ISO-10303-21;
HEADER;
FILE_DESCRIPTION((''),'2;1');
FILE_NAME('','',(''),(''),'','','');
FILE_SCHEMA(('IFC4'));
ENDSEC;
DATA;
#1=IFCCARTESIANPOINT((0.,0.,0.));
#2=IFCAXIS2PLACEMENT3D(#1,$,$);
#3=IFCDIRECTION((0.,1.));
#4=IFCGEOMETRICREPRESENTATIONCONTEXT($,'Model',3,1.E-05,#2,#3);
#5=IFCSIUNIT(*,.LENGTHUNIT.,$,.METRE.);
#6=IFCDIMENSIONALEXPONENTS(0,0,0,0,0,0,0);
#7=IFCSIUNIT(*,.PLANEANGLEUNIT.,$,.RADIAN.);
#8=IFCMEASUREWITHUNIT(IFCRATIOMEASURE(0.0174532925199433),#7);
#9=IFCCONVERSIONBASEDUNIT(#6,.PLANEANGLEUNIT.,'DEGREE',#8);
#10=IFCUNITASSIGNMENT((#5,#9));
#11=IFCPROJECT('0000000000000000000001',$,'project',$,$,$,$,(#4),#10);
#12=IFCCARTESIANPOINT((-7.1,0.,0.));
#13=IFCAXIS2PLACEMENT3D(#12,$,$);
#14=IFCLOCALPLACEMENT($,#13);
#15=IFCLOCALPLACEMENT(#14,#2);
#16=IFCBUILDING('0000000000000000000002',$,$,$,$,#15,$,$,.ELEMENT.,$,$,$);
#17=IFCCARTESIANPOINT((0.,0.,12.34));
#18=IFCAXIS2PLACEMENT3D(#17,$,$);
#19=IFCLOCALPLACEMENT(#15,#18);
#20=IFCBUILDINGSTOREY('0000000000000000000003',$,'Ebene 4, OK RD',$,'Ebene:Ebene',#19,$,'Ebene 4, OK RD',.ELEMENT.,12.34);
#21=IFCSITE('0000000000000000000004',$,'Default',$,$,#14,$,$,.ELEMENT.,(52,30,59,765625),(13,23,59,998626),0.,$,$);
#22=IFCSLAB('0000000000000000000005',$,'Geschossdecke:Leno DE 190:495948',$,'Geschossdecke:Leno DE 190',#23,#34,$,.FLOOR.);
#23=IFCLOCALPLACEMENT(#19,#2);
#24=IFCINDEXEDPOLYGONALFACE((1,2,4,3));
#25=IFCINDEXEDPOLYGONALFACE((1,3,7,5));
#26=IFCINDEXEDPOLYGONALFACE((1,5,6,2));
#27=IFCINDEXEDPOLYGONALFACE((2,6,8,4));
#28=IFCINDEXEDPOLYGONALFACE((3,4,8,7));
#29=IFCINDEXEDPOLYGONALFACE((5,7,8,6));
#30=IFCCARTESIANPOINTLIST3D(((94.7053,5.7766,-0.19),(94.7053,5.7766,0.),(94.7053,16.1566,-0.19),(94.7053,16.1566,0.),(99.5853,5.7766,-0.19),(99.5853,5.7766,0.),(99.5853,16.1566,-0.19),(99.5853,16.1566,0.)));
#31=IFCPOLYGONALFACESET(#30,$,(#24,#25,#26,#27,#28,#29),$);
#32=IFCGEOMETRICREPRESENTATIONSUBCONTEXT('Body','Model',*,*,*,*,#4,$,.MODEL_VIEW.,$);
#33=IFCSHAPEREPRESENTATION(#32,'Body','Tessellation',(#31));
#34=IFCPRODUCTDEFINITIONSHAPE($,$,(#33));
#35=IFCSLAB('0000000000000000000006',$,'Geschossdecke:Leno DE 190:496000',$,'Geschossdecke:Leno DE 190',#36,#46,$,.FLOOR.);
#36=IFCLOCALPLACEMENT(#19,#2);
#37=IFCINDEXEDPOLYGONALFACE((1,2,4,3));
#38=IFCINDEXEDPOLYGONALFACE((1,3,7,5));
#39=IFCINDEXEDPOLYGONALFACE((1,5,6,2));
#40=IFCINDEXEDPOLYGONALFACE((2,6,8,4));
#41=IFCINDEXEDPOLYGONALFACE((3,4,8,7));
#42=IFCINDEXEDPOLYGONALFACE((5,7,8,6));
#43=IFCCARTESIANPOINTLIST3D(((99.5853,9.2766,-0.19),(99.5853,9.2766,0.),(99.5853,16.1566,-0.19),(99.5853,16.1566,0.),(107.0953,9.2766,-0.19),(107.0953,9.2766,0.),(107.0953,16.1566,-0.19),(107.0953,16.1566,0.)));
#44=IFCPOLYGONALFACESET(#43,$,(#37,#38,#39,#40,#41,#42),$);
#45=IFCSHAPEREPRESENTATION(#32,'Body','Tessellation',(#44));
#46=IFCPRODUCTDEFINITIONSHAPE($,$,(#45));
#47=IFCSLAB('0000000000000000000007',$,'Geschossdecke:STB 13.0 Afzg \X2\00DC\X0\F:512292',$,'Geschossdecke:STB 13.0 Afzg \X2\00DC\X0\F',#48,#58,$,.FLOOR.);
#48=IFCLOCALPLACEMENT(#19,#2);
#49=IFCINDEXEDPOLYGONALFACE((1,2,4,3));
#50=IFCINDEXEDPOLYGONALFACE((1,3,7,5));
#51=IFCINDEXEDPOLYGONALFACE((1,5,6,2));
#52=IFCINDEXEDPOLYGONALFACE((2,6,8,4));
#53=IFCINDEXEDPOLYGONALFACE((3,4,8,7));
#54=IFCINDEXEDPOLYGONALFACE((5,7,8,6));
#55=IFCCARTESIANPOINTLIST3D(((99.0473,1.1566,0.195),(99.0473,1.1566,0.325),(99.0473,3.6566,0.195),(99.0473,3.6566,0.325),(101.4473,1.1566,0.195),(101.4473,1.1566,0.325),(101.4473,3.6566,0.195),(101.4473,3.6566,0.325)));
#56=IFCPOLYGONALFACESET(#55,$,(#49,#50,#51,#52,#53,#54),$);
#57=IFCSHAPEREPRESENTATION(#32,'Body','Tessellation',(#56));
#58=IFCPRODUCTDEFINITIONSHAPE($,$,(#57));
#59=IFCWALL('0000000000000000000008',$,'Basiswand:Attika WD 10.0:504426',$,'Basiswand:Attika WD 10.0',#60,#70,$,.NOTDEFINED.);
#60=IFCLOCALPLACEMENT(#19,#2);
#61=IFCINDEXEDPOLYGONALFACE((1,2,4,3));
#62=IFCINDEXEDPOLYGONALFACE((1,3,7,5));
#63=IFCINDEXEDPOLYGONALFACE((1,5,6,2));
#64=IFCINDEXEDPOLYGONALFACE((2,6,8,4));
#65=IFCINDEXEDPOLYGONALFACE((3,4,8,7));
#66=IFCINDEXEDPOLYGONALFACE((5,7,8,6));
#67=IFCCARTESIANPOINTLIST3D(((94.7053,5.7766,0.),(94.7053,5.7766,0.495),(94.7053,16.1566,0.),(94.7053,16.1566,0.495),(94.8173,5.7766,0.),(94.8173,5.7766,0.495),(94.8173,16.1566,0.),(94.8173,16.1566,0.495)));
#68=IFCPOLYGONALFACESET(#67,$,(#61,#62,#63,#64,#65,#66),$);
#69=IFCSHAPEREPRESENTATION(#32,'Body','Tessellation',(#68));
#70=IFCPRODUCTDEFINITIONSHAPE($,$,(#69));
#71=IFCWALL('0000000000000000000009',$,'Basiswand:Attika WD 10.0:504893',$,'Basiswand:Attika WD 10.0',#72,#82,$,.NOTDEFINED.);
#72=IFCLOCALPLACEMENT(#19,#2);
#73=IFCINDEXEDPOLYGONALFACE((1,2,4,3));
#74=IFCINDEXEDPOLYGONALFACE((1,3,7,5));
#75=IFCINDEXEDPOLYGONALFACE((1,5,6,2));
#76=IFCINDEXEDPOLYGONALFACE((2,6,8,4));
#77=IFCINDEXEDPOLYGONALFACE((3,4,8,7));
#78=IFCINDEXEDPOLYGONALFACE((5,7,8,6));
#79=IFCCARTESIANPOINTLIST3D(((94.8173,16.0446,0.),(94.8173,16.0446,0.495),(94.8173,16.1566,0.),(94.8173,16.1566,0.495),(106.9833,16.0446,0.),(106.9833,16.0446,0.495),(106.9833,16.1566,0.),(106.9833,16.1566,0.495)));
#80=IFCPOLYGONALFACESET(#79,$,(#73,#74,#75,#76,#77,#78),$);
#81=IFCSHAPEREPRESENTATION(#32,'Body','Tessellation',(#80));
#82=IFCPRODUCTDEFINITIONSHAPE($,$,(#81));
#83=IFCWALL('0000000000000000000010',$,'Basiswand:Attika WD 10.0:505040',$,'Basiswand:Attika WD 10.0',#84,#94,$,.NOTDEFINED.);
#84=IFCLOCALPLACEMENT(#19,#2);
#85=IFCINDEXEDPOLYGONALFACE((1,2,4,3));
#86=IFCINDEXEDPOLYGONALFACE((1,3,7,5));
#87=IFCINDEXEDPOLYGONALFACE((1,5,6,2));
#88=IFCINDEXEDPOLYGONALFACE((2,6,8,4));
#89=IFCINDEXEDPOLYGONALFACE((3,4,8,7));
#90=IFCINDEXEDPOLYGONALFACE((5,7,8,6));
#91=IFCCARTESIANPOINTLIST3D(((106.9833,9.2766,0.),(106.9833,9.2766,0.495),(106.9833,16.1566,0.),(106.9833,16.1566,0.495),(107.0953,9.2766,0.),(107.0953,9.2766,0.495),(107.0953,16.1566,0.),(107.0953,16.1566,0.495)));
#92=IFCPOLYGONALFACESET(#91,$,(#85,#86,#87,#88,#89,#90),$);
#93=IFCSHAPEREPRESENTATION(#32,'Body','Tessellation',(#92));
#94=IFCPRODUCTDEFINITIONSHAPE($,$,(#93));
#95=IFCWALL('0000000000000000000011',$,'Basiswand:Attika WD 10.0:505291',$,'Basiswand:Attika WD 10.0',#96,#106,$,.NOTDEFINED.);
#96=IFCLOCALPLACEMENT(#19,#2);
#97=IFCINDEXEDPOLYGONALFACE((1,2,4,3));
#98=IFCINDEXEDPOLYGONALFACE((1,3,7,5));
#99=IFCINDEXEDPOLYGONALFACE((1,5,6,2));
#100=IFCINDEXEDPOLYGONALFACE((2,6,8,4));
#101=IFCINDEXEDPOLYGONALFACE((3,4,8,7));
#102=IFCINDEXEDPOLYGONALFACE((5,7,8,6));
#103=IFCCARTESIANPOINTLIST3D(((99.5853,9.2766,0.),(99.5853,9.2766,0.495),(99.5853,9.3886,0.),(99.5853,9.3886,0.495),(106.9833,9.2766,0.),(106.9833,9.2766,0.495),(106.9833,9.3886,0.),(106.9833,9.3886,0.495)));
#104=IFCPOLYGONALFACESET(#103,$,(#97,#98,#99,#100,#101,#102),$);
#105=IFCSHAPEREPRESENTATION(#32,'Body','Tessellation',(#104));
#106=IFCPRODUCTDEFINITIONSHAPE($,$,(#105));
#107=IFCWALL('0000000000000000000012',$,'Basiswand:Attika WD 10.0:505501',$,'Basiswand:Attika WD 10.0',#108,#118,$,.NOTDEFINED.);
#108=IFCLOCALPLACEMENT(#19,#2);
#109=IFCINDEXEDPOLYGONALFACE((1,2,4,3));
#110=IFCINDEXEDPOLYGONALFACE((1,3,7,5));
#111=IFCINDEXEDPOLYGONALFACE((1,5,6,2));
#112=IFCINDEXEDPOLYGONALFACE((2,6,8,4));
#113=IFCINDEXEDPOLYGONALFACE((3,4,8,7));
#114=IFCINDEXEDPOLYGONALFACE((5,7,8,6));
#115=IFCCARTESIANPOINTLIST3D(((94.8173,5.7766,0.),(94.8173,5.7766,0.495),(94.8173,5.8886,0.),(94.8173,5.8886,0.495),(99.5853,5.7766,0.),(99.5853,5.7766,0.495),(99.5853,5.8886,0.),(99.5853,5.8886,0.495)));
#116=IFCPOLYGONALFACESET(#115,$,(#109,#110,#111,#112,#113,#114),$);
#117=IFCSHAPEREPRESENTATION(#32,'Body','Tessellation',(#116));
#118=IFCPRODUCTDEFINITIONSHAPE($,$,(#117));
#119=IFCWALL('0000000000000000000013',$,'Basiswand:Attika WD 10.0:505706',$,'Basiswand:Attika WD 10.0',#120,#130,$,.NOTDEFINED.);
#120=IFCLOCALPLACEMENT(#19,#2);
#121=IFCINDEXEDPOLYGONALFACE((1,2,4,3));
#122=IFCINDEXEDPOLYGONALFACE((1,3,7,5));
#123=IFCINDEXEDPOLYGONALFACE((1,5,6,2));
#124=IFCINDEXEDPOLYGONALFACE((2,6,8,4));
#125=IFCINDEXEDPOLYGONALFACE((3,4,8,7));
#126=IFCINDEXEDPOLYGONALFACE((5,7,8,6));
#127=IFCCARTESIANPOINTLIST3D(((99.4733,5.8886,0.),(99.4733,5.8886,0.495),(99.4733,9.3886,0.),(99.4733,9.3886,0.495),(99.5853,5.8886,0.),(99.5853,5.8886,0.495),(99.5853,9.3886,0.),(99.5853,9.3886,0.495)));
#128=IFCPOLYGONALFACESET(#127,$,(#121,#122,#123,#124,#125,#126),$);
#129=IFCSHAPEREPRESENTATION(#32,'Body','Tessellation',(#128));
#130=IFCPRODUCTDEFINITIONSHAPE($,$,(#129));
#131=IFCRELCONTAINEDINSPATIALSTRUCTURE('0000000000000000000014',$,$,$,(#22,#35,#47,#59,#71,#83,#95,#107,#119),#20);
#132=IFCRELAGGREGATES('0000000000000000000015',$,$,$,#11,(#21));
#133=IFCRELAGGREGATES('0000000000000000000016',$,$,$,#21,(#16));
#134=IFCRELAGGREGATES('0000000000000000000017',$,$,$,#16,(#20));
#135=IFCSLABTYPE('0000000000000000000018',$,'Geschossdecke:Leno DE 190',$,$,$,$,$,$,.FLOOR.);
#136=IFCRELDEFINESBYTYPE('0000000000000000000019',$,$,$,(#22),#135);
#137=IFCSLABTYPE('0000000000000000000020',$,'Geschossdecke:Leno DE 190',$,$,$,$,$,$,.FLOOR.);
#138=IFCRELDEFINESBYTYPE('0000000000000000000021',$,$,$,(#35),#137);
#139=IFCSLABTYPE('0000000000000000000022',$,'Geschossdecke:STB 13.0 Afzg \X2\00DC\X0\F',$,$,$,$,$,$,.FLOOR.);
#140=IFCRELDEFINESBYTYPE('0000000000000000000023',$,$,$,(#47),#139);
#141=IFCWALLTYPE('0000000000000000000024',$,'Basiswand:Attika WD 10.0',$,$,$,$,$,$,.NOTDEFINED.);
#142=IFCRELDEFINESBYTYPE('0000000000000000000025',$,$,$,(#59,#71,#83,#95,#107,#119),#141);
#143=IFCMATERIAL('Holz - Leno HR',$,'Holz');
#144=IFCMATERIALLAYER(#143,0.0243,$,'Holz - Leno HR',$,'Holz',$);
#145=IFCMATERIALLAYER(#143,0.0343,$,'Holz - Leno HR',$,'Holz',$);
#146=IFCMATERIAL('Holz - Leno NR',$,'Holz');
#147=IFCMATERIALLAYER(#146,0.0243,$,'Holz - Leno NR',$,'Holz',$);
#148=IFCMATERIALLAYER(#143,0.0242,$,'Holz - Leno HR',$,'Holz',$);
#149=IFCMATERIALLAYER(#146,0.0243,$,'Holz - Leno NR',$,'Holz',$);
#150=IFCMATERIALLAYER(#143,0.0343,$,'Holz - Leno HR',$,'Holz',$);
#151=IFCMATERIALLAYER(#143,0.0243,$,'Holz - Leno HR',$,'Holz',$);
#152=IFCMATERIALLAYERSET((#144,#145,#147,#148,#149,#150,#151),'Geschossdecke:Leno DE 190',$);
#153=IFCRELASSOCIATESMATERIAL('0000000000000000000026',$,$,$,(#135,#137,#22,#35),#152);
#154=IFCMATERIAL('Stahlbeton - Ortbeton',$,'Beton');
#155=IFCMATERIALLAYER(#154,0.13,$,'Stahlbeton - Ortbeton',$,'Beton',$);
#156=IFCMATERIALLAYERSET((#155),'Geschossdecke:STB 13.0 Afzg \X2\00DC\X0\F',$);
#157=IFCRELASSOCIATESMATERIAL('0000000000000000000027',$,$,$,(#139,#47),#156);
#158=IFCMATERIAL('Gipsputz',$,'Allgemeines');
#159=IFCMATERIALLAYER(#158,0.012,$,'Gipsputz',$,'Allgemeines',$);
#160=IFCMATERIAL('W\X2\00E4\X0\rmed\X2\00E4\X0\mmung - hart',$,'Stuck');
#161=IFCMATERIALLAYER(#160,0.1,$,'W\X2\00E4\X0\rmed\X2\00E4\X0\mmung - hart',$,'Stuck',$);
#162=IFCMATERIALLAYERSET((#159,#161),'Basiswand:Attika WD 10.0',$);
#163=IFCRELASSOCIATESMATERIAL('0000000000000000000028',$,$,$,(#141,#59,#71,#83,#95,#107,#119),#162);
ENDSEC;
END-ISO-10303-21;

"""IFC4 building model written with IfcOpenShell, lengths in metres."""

from ifc_helpers import new_model, entity, si_unit, converted_unit, direction, frame, frame_2d, origin, origin_2d_with_axis, place, context, subcontext, project, spatial, rectangle, extrude, material, layer, layer_set, layer_usage, type_object, element, save


model = new_model("IFC4")

# Units and contexts
model_context = context("Model", 3, precision=1e-05, world=origin(), true_north=direction((0.0, 1.0)))
body_context = subcontext(model_context, "Body", "Model", "MODEL_VIEW")
ifc_project = project(units=[si_unit("LENGTHUNIT", "METRE"), converted_unit("PLANEANGLEUNIT", "DEGREE", entity("IfcRatioMeasure", 0.0174532925199433), si_unit("PLANEANGLEUNIT", "RADIAN"), dimensions=[0, 0, 0, 0, 0, 0, 0])], contexts=[model_context])

# Site, building, storey
site_placement = place(None, frame((-7.1, 0.0, 0.0)))
site = spatial("IfcSite", under=ifc_project, at=site_placement, Name="Default", CompositionType="ELEMENT", RefLatitude=(52, 30, 59, 765625), RefLongitude=(13, 23, 59, 998626), RefElevation=0.0)
building_placement = place(site_placement, origin())
building = spatial("IfcBuilding", under=site, at=building_placement, CompositionType="ELEMENT")
storey_placement = place(building_placement, frame((0.0, 0.0, 12.34)))
storey = spatial("IfcBuildingStorey", under=building, at=storey_placement, Name="Ebene 4, OK RD", ObjectType="Ebene:Ebene", LongName="Ebene 4, OK RD", CompositionType="ELEMENT", Elevation=12.34)

# Slabs
ifc_material_1 = material(Name="Holz - Leno HR", Category="Holz")
ifc_layer_1 = layer(ifc_material_1, 0.0243, Name="Holz - Leno HR", Category="Holz")
ifc_layer_2 = layer(ifc_material_1, 0.0343, Name="Holz - Leno HR", Category="Holz")
ifc_material_2 = material(Name="Holz - Leno NR", Category="Holz")
ifc_layer_3 = layer(ifc_material_2, 0.0243, Name="Holz - Leno NR", Category="Holz")
ifc_layer_4 = layer(ifc_material_1, 0.0242, Name="Holz - Leno HR", Category="Holz")
ifc_layer_5 = layer(ifc_material_2, 0.0243, Name="Holz - Leno NR", Category="Holz")
ifc_layer_6 = layer(ifc_material_1, 0.0343, Name="Holz - Leno HR", Category="Holz")
ifc_layer_7 = layer(ifc_material_1, 0.0243, Name="Holz - Leno HR", Category="Holz")
ifc_layer_set_1 = layer_set([ifc_layer_1, ifc_layer_2, ifc_layer_3, ifc_layer_4, ifc_layer_5, ifc_layer_6, ifc_layer_7], Name="Geschossdecke:Leno DE 190")
ifc_layer_usage_1 = layer_usage(ifc_layer_set_1, "AXIS3", "POSITIVE", 0.0)
slab_type_1 = type_object("IfcSlabType", Name="Geschossdecke:Leno DE 190", PredefinedType="FLOOR", material=ifc_layer_set_1)
slab_1_placement = place(storey_placement, origin())
element("IfcSlab", 1, at=slab_1_placement, inside=storey, type_object=slab_type_1, material=ifc_layer_usage_1, Name="Geschossdecke:Leno DE 190:495948", ObjectType="Geschossdecke:Leno DE 190", PredefinedType="FLOOR", context=body_context, shape_type="SweptSolid", body=[
    extrude(rectangle(XDim=10.38, YDim=4.88, at=frame_2d((0.0, 0.0), x_axis=(1.0, 0.0))), frame((97.1453, 10.9666, 0.0), z_axis=(0.0, 0.0, -1.0), x_axis=(0.0, 1.0, 0.0)), (0.0, 0.0, 1.0), 0.19),
])
ifc_layer_usage_2 = layer_usage(ifc_layer_set_1, "AXIS3", "POSITIVE", 0.0)
slab_type_2 = type_object("IfcSlabType", Name="Geschossdecke:Leno DE 190", PredefinedType="FLOOR", material=ifc_layer_set_1)
slab_2_placement = place(storey_placement, origin())
element("IfcSlab", 2, at=slab_2_placement, inside=storey, type_object=slab_type_2, material=ifc_layer_usage_2, Name="Geschossdecke:Leno DE 190:496000", ObjectType="Geschossdecke:Leno DE 190", PredefinedType="FLOOR", context=body_context, shape_type="SweptSolid", body=[
    extrude(rectangle(XDim=6.88, YDim=7.51, at=frame_2d((0.0, 0.0), x_axis=(1.0, 0.0))), frame((103.3403, 12.7166, 0.0), z_axis=(0.0, 0.0, -1.0), x_axis=(0.0, 1.0, 0.0)), (0.0, 0.0, 1.0), 0.19),
])
ifc_material_3 = material(Name="Wärmedämmung - hart", Category="Stuck")
ifc_material_4 = material(Name="Stahlbeton - Ortbeton", Category="Beton")
ifc_layer_8 = layer(ifc_material_4, 0.13, Name="Stahlbeton - Ortbeton", Category="Beton")
ifc_layer_set_2 = layer_set([ifc_layer_8], Name="Geschossdecke:STB 13.0 Afzg ÜF")
ifc_layer_usage_3 = layer_usage(ifc_layer_set_2, "AXIS3", "POSITIVE", 0.0)
slab_type_3 = type_object("IfcSlabType", Name="Geschossdecke:STB 13.0 Afzg ÜF", PredefinedType="FLOOR", material=ifc_layer_set_2)
slab_3_placement = place(storey_placement, origin())
element("IfcSlab", 3, at=slab_3_placement, inside=storey, type_object=slab_type_3, material=ifc_layer_usage_3, Name="Geschossdecke:STB 13.0 Afzg ÜF:512292", ObjectType="Geschossdecke:STB 13.0 Afzg ÜF", PredefinedType="FLOOR", context=body_context, shape_type="SweptSolid", body=[
    extrude(rectangle(XDim=2.5, YDim=2.4, at=origin_2d_with_axis()), frame((100.2473, 2.4066, 0.325), z_axis=(0.0, 0.0, -1.0), x_axis=(0.0, 1.0, 0.0)), (0.0, 0.0, 1.0), 0.13),
])

# Walls
ifc_material_5 = material(Name="Gipsputz", Category="Allgemeines")
ifc_layer_9 = layer(ifc_material_5, 0.012, Name="Gipsputz", Category="Allgemeines")
ifc_layer_10 = layer(ifc_material_3, 0.1, Name="Wärmedämmung - hart", Category="Stuck")
ifc_layer_set_3 = layer_set([ifc_layer_9, ifc_layer_10], Name="Basiswand:Attika WD 10.0")
ifc_layer_usage_4 = layer_usage(ifc_layer_set_3, "AXIS2", "NEGATIVE", 0.056)
wall_type = type_object("IfcWallType", Name="Basiswand:Attika WD 10.0", PredefinedType="NOTDEFINED", material=ifc_layer_set_3)
wall_1_placement = place(storey_placement, frame((94.7613, 16.1566, 0.0), z_axis=(0.0, 0.0, 1.0), x_axis=(0.0, -1.0, 0.0)))
element("IfcWall", 4, at=wall_1_placement, inside=storey, type_object=wall_type, material=ifc_layer_usage_4, Name="Basiswand:Attika WD 10.0:504426", ObjectType="Basiswand:Attika WD 10.0", PredefinedType="NOTDEFINED", context=body_context, shape_type="SweptSolid", body=[
    extrude(rectangle(XDim=10.38, YDim=0.112, at=frame_2d((5.19, 0.0), x_axis=(-1.0, 0.0))), origin(), (0.0, 0.0, 1.0), 0.495),
])
ifc_layer_usage_5 = layer_usage(ifc_layer_set_3, "AXIS2", "NEGATIVE", 0.056)
wall_2_placement = place(storey_placement, frame((106.9833, 16.1006, 0.0), z_axis=(0.0, 0.0, 1.0), x_axis=(-1.0, 0.0, 0.0)))
element("IfcWall", 5, at=wall_2_placement, inside=storey, type_object=wall_type, material=ifc_layer_usage_5, Name="Basiswand:Attika WD 10.0:504893", ObjectType="Basiswand:Attika WD 10.0", PredefinedType="NOTDEFINED", context=body_context, shape_type="SweptSolid", body=[
    extrude(rectangle(XDim=12.166, YDim=0.112, at=frame_2d((6.083, 0.0), x_axis=(-1.0, 0.0))), origin(), (0.0, 0.0, 1.0), 0.495),
])
ifc_layer_usage_6 = layer_usage(ifc_layer_set_3, "AXIS2", "POSITIVE", -0.056)
wall_3_placement = place(storey_placement, frame((107.0393, 16.1566, 0.0), z_axis=(0.0, 0.0, 1.0), x_axis=(0.0, -1.0, 0.0)))
element("IfcWall", 6, at=wall_3_placement, inside=storey, type_object=wall_type, material=ifc_layer_usage_6, Name="Basiswand:Attika WD 10.0:505040", ObjectType="Basiswand:Attika WD 10.0", PredefinedType="NOTDEFINED", context=body_context, shape_type="SweptSolid", body=[
    extrude(rectangle(XDim=6.88, YDim=0.112, at=frame_2d((3.44, 0.0), x_axis=(-1.0, 0.0))), origin(), (0.0, 0.0, 1.0), 0.495),
])
ifc_layer_usage_7 = layer_usage(ifc_layer_set_3, "AXIS2", "POSITIVE", -0.056)
wall_4_placement = place(storey_placement, frame((106.9833, 9.3326, 0.0), z_axis=(0.0, 0.0, 1.0), x_axis=(-1.0, 0.0, 0.0)))
element("IfcWall", 7, at=wall_4_placement, inside=storey, type_object=wall_type, material=ifc_layer_usage_7, Name="Basiswand:Attika WD 10.0:505291", ObjectType="Basiswand:Attika WD 10.0", PredefinedType="NOTDEFINED", context=body_context, shape_type="SweptSolid", body=[
    extrude(rectangle(XDim=7.398, YDim=0.112, at=frame_2d((3.699, 0.0), x_axis=(-1.0, 0.0))), origin(), (0.0, 0.0, 1.0), 0.495),
])
ifc_layer_usage_8 = layer_usage(ifc_layer_set_3, "AXIS2", "POSITIVE", -0.056)
wall_5_placement = place(storey_placement, frame((99.5853, 5.8326, 0.0), z_axis=(0.0, 0.0, 1.0), x_axis=(-1.0, 0.0, 0.0)))
element("IfcWall", 8, at=wall_5_placement, inside=storey, type_object=wall_type, material=ifc_layer_usage_8, Name="Basiswand:Attika WD 10.0:505501", ObjectType="Basiswand:Attika WD 10.0", PredefinedType="NOTDEFINED", context=body_context, shape_type="SweptSolid", body=[
    extrude(rectangle(XDim=4.768, YDim=0.112, at=frame_2d((2.384, 0.0), x_axis=(-1.0, 0.0))), origin(), (0.0, 0.0, 1.0), 0.495),
])
ifc_layer_usage_9 = layer_usage(ifc_layer_set_3, "AXIS2", "POSITIVE", -0.056)
wall_6_placement = place(storey_placement, frame((99.5293, 9.3886, 0.0), z_axis=(0.0, 0.0, 1.0), x_axis=(0.0, -1.0, 0.0)))
element("IfcWall", 9, at=wall_6_placement, inside=storey, type_object=wall_type, material=ifc_layer_usage_9, Name="Basiswand:Attika WD 10.0:505706", ObjectType="Basiswand:Attika WD 10.0", PredefinedType="NOTDEFINED", context=body_context, shape_type="SweptSolid", body=[
    extrude(rectangle(XDim=3.5, YDim=0.112, at=frame_2d((1.75, 0.0), x_axis=(-1.0, 0.0))), origin(), (0.0, 0.0, 1.0), 0.495),
])

save(model, "model.ifc")
